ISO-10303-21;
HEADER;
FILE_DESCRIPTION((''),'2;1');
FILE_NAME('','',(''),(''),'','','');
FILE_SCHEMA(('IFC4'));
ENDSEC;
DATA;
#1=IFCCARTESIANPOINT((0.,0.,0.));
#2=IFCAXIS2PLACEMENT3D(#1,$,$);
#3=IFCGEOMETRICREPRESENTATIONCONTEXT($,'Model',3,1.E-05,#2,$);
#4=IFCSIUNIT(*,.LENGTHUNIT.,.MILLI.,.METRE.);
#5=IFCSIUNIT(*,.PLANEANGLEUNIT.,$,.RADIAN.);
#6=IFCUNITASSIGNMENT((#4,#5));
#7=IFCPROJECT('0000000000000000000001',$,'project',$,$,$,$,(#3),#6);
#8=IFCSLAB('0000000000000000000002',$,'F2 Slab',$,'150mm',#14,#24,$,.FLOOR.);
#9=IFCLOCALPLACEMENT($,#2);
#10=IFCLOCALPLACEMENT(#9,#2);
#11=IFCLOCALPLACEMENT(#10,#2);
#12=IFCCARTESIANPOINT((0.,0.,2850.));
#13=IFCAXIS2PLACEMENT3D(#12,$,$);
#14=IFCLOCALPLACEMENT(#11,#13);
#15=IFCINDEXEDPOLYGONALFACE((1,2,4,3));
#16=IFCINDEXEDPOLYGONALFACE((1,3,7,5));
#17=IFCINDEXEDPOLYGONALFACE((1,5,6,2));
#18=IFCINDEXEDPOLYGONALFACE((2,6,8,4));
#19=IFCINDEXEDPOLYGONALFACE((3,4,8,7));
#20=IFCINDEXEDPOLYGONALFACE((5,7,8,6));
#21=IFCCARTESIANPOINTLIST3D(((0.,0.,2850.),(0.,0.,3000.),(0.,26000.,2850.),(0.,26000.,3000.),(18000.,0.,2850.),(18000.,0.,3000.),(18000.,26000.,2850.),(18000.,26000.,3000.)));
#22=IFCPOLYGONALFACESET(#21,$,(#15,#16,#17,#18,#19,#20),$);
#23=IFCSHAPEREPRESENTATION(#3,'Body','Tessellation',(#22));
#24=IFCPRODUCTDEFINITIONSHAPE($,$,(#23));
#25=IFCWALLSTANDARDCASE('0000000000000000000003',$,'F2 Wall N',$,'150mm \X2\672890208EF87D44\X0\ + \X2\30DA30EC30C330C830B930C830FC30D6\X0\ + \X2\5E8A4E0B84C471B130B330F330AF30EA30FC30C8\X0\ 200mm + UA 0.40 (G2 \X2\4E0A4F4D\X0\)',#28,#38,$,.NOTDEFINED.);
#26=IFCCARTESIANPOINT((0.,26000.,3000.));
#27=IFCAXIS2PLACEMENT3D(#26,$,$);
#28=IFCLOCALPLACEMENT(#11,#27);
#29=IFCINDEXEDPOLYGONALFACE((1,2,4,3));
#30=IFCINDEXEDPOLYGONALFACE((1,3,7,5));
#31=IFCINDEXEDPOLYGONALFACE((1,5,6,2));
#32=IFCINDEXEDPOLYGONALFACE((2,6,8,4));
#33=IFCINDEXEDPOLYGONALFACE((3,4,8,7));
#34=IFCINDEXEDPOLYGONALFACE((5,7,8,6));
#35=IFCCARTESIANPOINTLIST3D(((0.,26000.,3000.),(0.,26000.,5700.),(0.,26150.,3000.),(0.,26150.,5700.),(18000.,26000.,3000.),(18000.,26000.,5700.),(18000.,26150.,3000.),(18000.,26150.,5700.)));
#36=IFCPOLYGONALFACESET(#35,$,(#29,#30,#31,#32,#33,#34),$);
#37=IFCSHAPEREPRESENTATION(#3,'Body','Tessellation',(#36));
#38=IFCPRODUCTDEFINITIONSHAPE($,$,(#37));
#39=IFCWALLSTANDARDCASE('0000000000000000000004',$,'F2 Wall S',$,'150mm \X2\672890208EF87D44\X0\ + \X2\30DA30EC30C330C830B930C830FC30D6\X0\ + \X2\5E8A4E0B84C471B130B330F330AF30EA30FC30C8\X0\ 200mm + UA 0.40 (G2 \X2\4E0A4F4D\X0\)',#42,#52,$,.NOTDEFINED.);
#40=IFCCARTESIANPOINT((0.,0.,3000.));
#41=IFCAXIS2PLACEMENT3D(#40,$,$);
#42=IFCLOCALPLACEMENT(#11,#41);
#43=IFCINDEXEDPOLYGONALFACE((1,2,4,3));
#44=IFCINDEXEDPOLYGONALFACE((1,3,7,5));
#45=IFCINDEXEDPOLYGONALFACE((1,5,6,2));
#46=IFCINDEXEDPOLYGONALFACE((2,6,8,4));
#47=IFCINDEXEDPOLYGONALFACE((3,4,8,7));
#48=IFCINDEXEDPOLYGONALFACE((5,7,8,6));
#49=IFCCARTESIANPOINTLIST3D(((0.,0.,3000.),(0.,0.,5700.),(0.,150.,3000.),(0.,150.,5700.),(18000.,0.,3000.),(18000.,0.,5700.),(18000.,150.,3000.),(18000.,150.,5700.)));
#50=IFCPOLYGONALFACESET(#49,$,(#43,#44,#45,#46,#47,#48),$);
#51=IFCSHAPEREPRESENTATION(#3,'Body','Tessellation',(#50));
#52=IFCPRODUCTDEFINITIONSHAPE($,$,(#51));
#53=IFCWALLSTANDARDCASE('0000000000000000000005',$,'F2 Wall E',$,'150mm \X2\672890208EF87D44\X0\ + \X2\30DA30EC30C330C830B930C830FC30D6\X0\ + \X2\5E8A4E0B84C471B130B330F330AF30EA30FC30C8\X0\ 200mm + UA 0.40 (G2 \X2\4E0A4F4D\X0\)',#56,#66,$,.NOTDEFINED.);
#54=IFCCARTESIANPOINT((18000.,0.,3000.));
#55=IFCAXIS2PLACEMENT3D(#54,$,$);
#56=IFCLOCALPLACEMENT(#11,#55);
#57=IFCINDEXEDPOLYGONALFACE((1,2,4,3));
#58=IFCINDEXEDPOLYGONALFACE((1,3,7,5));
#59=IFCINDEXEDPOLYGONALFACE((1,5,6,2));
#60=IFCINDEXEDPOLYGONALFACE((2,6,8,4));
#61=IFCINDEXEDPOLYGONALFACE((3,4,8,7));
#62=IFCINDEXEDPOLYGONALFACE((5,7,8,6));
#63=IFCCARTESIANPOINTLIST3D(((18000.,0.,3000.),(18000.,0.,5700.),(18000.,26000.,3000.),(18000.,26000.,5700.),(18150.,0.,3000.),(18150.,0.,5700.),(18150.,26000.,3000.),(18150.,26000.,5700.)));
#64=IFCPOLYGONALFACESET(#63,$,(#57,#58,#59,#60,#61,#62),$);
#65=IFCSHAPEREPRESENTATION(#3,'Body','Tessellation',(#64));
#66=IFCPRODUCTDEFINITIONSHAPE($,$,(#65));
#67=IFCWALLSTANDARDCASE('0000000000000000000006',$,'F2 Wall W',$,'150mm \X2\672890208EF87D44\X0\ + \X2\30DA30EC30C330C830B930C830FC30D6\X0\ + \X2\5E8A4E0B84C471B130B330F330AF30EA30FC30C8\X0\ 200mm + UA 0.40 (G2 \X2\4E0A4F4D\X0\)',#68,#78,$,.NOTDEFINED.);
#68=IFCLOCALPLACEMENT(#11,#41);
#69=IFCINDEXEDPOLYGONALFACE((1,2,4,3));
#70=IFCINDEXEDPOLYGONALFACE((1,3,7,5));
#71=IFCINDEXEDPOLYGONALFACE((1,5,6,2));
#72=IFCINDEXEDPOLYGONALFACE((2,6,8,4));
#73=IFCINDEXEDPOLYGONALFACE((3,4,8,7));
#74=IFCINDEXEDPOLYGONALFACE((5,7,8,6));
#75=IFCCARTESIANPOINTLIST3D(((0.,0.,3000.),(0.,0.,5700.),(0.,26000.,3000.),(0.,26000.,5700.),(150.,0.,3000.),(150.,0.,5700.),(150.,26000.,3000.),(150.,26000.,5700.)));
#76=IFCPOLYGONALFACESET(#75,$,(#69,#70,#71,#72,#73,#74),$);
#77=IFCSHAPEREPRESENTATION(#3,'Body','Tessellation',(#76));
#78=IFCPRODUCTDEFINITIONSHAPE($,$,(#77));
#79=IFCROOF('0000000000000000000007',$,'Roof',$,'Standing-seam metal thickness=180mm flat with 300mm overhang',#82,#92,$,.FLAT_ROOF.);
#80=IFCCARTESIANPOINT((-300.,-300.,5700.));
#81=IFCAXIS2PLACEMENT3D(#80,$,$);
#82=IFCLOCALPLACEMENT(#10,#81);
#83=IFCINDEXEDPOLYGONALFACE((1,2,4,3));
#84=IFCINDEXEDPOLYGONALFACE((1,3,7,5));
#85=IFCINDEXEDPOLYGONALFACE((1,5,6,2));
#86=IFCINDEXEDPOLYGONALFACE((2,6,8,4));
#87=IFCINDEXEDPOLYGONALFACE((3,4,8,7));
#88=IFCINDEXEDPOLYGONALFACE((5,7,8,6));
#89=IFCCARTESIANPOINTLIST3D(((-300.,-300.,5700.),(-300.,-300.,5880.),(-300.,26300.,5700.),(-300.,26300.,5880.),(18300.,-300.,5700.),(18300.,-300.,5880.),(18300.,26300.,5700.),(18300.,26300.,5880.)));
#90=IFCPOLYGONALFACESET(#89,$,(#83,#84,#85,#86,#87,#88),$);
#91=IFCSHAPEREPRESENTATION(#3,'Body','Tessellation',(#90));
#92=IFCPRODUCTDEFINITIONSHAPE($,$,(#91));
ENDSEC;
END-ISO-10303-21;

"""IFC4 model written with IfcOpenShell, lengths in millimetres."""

from ifc_helpers import new_model, si_unit, frame, frame_2d, origin, place, context, project, rectangle, extrude, element, save


model = new_model("IFC4")

# Units and contexts
model_context = context("Model", 3, precision=1e-05, world=origin())
ifc_project = project(units=[si_unit("LENGTHUNIT", "METRE", prefix="MILLI"), si_unit("PLANEANGLEUNIT", "RADIAN")], contexts=[model_context])

# Slab
placement_1 = place(None, origin())
placement_2 = place(placement_1, origin())
placement_3 = place(placement_2, origin())
slab_placement = place(placement_3, frame((0.0, 0.0, 2850.0)))
element("IfcSlab", 1, at=slab_placement, Name="F2 Slab", ObjectType="150mm", PredefinedType="FLOOR", context=model_context, shape_type="SweptSolid", body=[
    extrude(rectangle(XDim=18000.0, YDim=26000.0, at=frame_2d((9000.0, 13000.0))), frame((0.0, 0.0, 2850.0)), (0.0, 0.0, 1.0), 150.0),
])

# Walls
wall_1_placement = place(placement_3, frame((0.0, 26000.0, 3000.0)))
element("IfcWallStandardCase", 2, at=wall_1_placement, Name="F2 Wall N", ObjectType="150mm 木造軸組 + ペレットストーブ + 床下蓄熱コンクリート 200mm + UA 0.40 (G2 上位)", PredefinedType="NOTDEFINED", context=model_context, shape_type="SweptSolid", body=[
    extrude(rectangle(XDim=18000.0, YDim=150.0, at=frame_2d((9000.0, 75.0))), frame((0.0, 26000.0, 3000.0)), (0.0, 0.0, 1.0), 2700.0),
])
wall_2_placement = place(placement_3, frame((0.0, 0.0, 3000.0)))
element("IfcWallStandardCase", 3, at=wall_2_placement, Name="F2 Wall S", ObjectType="150mm 木造軸組 + ペレットストーブ + 床下蓄熱コンクリート 200mm + UA 0.40 (G2 上位)", PredefinedType="NOTDEFINED", context=model_context, shape_type="SweptSolid", body=[
    extrude(rectangle(XDim=18000.0, YDim=150.0, at=frame_2d((9000.0, 75.0))), frame((0.0, 0.0, 3000.0)), (0.0, 0.0, 1.0), 2700.0),
])
wall_3_placement = place(placement_3, frame((18000.0, 0.0, 3000.0)))
element("IfcWallStandardCase", 4, at=wall_3_placement, Name="F2 Wall E", ObjectType="150mm 木造軸組 + ペレットストーブ + 床下蓄熱コンクリート 200mm + UA 0.40 (G2 上位)", PredefinedType="NOTDEFINED", context=model_context, shape_type="SweptSolid", body=[
    extrude(rectangle(XDim=150.0, YDim=26000.0, at=frame_2d((75.0, 13000.0))), frame((18000.0, 0.0, 3000.0)), (0.0, 0.0, 1.0), 2700.0),
])
wall_4_placement = place(placement_3, frame((0.0, 0.0, 3000.0)))
element("IfcWallStandardCase", 5, at=wall_4_placement, Name="F2 Wall W", ObjectType="150mm 木造軸組 + ペレットストーブ + 床下蓄熱コンクリート 200mm + UA 0.40 (G2 上位)", PredefinedType="NOTDEFINED", context=model_context, shape_type="SweptSolid", body=[
    extrude(rectangle(XDim=150.0, YDim=26000.0, at=frame_2d((75.0, 13000.0))), frame((0.0, 0.0, 3000.0)), (0.0, 0.0, 1.0), 2700.0),
])

# Roof
roof_placement = place(placement_2, frame((-300.0, -300.0, 5700.0)))
element("IfcRoof", 6, at=roof_placement, Name="Roof", ObjectType="Standing-seam metal thickness=180mm flat with 300mm overhang", PredefinedType="FLAT_ROOF", context=model_context, shape_type="SweptSolid", body=[
    extrude(rectangle(XDim=18600.0, YDim=26600.0, at=frame_2d((9300.0, 13300.0))), frame((-300.0, -300.0, 5700.0)), (0.0, 0.0, 1.0), 180.0),
])

save(model, "model.ifc")
